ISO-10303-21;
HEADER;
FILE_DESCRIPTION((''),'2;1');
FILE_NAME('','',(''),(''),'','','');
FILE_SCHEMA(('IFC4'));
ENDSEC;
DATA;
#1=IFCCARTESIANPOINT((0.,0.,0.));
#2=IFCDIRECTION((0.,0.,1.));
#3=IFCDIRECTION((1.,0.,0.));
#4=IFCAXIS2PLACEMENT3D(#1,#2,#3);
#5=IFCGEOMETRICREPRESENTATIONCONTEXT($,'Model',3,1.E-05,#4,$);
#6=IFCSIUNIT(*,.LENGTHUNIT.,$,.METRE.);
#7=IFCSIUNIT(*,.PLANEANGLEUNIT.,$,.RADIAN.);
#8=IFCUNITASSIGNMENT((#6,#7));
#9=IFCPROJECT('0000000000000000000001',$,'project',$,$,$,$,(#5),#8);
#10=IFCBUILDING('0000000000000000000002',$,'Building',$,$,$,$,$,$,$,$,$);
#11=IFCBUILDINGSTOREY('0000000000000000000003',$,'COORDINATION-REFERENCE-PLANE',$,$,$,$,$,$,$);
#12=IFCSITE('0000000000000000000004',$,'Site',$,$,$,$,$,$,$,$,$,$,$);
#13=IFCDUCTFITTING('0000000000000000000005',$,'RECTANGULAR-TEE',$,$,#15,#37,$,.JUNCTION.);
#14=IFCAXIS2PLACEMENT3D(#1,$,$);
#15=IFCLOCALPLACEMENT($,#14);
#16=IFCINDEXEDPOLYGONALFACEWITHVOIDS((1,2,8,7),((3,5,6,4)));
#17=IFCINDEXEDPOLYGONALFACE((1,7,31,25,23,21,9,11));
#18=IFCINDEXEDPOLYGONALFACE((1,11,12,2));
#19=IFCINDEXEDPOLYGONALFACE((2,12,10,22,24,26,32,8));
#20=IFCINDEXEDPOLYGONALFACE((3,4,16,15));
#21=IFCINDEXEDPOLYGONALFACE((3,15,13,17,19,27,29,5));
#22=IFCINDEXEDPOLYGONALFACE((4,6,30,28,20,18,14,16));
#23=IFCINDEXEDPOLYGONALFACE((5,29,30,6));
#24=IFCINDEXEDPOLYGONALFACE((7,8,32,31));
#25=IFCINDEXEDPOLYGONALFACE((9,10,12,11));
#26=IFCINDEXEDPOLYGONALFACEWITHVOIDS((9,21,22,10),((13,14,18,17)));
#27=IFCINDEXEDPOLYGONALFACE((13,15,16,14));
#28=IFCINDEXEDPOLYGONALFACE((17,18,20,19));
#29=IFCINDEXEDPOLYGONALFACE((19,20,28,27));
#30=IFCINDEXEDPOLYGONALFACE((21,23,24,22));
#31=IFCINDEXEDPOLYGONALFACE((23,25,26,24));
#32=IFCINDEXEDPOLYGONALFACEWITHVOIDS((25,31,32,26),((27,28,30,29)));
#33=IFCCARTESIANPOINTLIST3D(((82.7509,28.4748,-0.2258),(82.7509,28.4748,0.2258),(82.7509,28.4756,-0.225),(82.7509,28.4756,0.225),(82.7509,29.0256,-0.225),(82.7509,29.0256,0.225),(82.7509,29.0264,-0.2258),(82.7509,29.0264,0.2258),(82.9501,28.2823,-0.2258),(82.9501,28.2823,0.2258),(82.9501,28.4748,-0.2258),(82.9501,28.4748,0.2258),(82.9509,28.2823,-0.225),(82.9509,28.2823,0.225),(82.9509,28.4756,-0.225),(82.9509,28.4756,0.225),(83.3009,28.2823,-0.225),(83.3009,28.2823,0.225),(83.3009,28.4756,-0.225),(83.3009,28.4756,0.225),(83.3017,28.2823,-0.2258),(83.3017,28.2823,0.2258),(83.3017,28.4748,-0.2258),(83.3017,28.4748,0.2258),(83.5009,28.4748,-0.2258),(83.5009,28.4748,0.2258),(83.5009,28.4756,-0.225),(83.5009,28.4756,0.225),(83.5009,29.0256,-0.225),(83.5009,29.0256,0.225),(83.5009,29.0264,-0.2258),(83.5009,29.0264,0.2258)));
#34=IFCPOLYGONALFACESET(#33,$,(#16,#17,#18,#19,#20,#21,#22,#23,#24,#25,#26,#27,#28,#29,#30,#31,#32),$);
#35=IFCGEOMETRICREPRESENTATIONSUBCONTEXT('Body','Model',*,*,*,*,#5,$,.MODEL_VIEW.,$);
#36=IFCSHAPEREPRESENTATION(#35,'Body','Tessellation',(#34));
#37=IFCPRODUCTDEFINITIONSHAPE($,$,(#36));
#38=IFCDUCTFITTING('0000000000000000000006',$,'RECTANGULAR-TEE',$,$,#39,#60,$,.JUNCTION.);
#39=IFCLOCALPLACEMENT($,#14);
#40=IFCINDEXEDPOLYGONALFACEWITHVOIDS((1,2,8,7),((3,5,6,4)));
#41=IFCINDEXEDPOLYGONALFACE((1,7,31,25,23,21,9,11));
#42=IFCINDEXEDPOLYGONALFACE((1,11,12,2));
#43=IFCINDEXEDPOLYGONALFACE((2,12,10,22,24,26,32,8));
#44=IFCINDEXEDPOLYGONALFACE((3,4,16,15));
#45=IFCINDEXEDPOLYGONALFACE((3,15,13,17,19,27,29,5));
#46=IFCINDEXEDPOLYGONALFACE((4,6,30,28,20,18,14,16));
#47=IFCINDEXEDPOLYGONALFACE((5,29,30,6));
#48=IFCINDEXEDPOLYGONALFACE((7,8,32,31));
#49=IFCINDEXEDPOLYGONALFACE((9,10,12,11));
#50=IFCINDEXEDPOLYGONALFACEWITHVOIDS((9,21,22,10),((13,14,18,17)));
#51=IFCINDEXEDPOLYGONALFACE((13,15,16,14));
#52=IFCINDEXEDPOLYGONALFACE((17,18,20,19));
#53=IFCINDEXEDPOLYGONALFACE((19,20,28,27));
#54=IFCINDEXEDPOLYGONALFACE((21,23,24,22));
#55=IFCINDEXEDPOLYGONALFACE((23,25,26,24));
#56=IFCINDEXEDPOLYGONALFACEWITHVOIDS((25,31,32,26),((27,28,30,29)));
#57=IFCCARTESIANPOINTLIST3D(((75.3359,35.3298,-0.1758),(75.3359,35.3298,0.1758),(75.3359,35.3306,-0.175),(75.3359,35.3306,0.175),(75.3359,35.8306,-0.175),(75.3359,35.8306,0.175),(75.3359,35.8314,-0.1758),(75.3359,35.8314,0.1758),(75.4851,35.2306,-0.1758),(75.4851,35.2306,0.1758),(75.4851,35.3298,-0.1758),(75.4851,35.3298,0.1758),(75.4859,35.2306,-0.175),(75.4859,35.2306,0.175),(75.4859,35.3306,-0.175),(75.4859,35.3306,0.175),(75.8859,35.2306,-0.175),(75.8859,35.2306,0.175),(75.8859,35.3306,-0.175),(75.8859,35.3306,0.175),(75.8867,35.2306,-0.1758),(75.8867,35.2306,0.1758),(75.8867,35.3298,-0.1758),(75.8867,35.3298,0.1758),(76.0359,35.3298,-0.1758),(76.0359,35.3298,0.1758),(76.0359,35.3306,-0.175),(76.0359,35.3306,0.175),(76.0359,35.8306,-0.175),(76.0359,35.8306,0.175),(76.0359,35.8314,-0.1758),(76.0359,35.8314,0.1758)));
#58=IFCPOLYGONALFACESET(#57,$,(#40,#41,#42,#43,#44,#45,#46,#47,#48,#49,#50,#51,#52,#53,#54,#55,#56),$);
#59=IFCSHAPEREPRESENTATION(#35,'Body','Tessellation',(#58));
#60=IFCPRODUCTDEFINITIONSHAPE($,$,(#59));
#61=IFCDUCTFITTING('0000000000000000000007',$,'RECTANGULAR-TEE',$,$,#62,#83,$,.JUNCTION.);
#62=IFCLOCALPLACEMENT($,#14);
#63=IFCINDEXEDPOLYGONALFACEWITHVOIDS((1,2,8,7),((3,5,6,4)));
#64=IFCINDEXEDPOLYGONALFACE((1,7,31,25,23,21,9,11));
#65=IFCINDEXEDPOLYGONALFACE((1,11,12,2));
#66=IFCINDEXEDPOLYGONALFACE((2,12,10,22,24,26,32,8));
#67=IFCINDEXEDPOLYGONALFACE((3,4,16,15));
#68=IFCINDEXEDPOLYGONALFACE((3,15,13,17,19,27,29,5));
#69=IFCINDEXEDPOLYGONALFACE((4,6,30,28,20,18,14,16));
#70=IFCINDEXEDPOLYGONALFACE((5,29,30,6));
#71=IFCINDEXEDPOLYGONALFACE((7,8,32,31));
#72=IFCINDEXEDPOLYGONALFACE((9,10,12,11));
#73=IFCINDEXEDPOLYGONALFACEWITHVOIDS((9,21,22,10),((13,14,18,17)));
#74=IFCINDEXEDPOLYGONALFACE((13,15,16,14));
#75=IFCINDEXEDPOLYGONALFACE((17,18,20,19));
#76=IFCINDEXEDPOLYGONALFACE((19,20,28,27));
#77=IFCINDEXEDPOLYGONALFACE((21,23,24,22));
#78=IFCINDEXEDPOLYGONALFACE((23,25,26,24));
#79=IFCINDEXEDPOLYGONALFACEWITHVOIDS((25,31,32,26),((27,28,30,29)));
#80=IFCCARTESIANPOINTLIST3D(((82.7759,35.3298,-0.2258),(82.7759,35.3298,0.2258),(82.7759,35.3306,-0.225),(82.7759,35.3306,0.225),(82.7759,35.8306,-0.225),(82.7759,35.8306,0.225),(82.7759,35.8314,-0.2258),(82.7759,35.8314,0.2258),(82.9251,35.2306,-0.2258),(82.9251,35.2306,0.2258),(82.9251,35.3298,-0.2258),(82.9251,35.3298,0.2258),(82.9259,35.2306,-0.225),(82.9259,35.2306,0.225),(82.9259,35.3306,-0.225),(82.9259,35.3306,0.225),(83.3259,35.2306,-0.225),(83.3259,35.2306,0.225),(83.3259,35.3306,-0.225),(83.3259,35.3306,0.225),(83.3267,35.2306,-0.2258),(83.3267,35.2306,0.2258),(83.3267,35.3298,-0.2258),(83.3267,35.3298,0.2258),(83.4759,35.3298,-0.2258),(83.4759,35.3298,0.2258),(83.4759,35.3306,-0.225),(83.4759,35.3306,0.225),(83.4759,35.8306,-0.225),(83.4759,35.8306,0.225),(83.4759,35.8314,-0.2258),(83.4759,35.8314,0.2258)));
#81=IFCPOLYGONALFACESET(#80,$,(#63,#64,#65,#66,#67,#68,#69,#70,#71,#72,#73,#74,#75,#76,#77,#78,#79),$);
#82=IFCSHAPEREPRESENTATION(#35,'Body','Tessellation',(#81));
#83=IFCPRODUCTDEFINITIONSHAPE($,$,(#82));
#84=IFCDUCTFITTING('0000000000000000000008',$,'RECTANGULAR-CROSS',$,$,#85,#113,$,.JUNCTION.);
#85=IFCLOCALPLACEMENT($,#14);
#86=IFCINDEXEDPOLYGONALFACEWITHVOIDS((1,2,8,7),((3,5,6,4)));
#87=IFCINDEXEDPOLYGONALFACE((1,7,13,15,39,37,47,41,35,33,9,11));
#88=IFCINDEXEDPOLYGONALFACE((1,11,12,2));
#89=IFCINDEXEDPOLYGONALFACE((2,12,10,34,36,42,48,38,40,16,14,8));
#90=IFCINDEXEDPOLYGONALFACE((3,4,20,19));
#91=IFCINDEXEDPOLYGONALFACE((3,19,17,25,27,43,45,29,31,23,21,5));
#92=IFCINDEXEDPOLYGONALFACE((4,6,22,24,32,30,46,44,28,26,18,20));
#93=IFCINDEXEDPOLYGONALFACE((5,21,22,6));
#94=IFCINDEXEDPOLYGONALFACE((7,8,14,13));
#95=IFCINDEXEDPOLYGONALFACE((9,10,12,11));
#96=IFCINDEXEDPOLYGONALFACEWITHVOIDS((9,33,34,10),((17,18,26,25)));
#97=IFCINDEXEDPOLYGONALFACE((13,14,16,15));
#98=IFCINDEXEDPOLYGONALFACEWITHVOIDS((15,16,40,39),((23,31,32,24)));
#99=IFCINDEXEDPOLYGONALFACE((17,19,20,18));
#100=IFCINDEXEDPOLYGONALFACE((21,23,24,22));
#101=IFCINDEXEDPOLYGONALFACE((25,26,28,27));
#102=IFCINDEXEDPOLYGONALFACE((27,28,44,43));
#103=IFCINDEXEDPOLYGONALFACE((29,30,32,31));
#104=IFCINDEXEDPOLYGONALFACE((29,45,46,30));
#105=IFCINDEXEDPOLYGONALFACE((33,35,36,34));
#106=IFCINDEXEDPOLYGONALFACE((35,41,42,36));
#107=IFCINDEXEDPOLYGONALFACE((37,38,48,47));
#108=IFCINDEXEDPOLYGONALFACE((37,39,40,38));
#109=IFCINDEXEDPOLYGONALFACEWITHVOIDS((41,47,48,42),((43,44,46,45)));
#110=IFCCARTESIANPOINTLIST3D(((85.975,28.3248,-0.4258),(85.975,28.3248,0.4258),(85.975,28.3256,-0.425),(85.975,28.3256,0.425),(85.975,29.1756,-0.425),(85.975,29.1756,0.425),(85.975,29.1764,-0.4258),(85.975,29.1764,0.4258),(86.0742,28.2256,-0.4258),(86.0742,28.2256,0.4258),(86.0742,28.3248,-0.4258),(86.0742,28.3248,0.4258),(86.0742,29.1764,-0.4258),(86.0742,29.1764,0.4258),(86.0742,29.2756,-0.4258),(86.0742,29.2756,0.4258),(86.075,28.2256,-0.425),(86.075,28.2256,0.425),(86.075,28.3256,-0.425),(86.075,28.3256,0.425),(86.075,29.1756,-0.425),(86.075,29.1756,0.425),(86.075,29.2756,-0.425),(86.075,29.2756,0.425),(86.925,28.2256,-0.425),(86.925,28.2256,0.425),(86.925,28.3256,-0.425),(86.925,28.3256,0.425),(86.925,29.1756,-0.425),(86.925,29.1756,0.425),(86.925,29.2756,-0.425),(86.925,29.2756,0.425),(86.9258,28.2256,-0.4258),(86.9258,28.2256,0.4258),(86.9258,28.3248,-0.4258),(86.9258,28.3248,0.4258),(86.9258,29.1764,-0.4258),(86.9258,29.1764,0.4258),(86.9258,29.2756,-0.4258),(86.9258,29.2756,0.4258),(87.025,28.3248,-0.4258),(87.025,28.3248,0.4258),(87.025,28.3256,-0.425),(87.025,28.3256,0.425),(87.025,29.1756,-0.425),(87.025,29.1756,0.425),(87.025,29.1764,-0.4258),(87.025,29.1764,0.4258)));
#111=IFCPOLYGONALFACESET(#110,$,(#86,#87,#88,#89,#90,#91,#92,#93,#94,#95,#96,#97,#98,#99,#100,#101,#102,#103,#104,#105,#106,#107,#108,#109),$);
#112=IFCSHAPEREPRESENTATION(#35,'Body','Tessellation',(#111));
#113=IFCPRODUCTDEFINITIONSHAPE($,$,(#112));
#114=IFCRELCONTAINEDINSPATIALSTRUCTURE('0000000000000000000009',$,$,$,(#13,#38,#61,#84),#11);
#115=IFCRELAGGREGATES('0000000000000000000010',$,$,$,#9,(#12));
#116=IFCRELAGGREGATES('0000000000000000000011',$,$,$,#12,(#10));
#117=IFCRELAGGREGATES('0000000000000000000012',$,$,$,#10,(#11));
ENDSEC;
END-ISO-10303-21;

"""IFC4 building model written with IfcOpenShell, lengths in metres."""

from ifc_helpers import new_model, si_unit, frame, origin_with_axes, place, context, subcontext, project, spatial, rectangle, extrude, boolean, element, save


model = new_model("IFC4")

# Units and contexts
model_context = context("Model", 3, precision=1e-05, world=origin_with_axes())
body_context = subcontext(model_context, "Body", "Model", "MODEL_VIEW")
ifc_project = project(units=[si_unit("LENGTHUNIT", "METRE"), si_unit("PLANEANGLEUNIT", "RADIAN")], contexts=[model_context])

# Site, building, storey
site = spatial("IfcSite", under=ifc_project, Name="Site")
building = spatial("IfcBuilding", under=site, Name="Building")
storey = spatial("IfcBuildingStorey", under=building, Name="COORDINATION-REFERENCE-PLANE")

# Duct fittings
duct_fitting_1_placement = place(None, frame((83.1259, 28.7506, 0.0), z_axis=(-1.0, 0.0, 0.0), x_axis=(0.0, -1.0, 0.0)))
solid_1 = boolean("UNION", extrude(rectangle(XDim=0.55, YDim=0.45), frame((0.0, 0.0, -0.375), z_axis=(0.0, 0.0, 1.0), x_axis=(1.0, 0.0, 0.0)), (0.0, 0.0, 1.0), 0.75), extrude(rectangle(XDim=0.35, YDim=0.45), frame((0.0, 0.0, 0.0), z_axis=(1.0, 0.0, 0.0), x_axis=(0.0, 0.0, -1.0)), (0.0, 0.0, 1.0), 0.4683))
element("IfcDuctFitting", 1, at=duct_fitting_1_placement, inside=storey, Name="RECTANGULAR-TEE", PredefinedType="JUNCTION", context=body_context, shape_type="CSG", body=[
    boolean("DIFFERENCE", boolean("UNION", extrude(rectangle(XDim=0.5516, YDim=0.4516), frame((0.0, 0.0, -0.375), z_axis=(0.0, 0.0, 1.0), x_axis=(1.0, 0.0, 0.0)), (0.0, 0.0, 1.0), 0.75), extrude(rectangle(XDim=0.3516, YDim=0.4516), frame((0.0, 0.0, 0.0), z_axis=(1.0, 0.0, 0.0), x_axis=(0.0, 0.0, -1.0)), (0.0, 0.0, 1.0), 0.4683)), solid_1),
])
duct_fitting_2_placement = place(None, frame((75.6859, 35.5806, 0.0), z_axis=(-1.0, 0.0, 0.0), x_axis=(0.0, -1.0, 0.0)))
solid_2 = boolean("UNION", extrude(rectangle(XDim=0.5, YDim=0.35), frame((0.0, 0.0, -0.35), z_axis=(0.0, 0.0, 1.0), x_axis=(1.0, 0.0, 0.0)), (0.0, 0.0, 1.0), 0.7), extrude(rectangle(XDim=0.4, YDim=0.35), frame((0.0, 0.0, 0.0), z_axis=(1.0, 0.0, 0.0), x_axis=(0.0, 0.0, -1.0)), (0.0, 0.0, 1.0), 0.35))
element("IfcDuctFitting", 2, at=duct_fitting_2_placement, inside=storey, Name="RECTANGULAR-TEE", PredefinedType="JUNCTION", context=body_context, shape_type="CSG", body=[
    boolean("DIFFERENCE", boolean("UNION", extrude(rectangle(XDim=0.5016, YDim=0.3516), frame((0.0, 0.0, -0.35), z_axis=(0.0, 0.0, 1.0), x_axis=(1.0, 0.0, 0.0)), (0.0, 0.0, 1.0), 0.7), extrude(rectangle(XDim=0.4016, YDim=0.3516), frame((0.0, 0.0, 0.0), z_axis=(1.0, 0.0, 0.0), x_axis=(0.0, 0.0, -1.0)), (0.0, 0.0, 1.0), 0.35)), solid_2),
])
duct_fitting_3_placement = place(None, frame((83.1259, 35.5806, 0.0), z_axis=(-1.0, 0.0, 0.0), x_axis=(0.0, -1.0, 0.0)))
solid_3 = boolean("UNION", extrude(rectangle(XDim=0.5, YDim=0.45), frame((0.0, 0.0, -0.35), z_axis=(0.0, 0.0, 1.0), x_axis=(1.0, 0.0, 0.0)), (0.0, 0.0, 1.0), 0.7), extrude(rectangle(XDim=0.4, YDim=0.45), frame((0.0, 0.0, 0.0), z_axis=(1.0, 0.0, 0.0), x_axis=(0.0, 0.0, -1.0)), (0.0, 0.0, 1.0), 0.35))
element("IfcDuctFitting", 3, at=duct_fitting_3_placement, inside=storey, Name="RECTANGULAR-TEE", PredefinedType="JUNCTION", context=body_context, shape_type="CSG", body=[
    boolean("DIFFERENCE", boolean("UNION", extrude(rectangle(XDim=0.5016, YDim=0.4516), frame((0.0, 0.0, -0.35), z_axis=(0.0, 0.0, 1.0), x_axis=(1.0, 0.0, 0.0)), (0.0, 0.0, 1.0), 0.7), extrude(rectangle(XDim=0.4016, YDim=0.4516), frame((0.0, 0.0, 0.0), z_axis=(1.0, 0.0, 0.0), x_axis=(0.0, 0.0, -1.0)), (0.0, 0.0, 1.0), 0.35)), solid_3),
])
duct_fitting_4_placement = place(None, frame((86.5, 28.7506, 0.0), z_axis=(0.0, -1.0, 0.0), x_axis=(1.0, 0.0, 0.0)))
solid_4 = boolean("UNION", extrude(rectangle(XDim=0.85, YDim=0.85), frame((0.0, 0.0, -0.525), z_axis=(0.0, 0.0, 1.0), x_axis=(1.0, 0.0, 0.0)), (0.0, 0.0, 1.0), 1.05), extrude(rectangle(XDim=0.85, YDim=0.85), frame((-0.525, 0.0, 0.0), z_axis=(1.0, 0.0, 0.0), x_axis=(0.0, 0.0, -1.0)), (0.0, 0.0, 1.0), 1.05))
element("IfcDuctFitting", 4, at=duct_fitting_4_placement, inside=storey, Name="RECTANGULAR-CROSS", PredefinedType="JUNCTION", context=body_context, shape_type="CSG", body=[
    boolean("DIFFERENCE", boolean("UNION", extrude(rectangle(XDim=0.8516, YDim=0.8516), frame((0.0, 0.0, -0.525), z_axis=(0.0, 0.0, 1.0), x_axis=(1.0, 0.0, 0.0)), (0.0, 0.0, 1.0), 1.05), extrude(rectangle(XDim=0.8516, YDim=0.8516), frame((-0.525, 0.0, 0.0), z_axis=(1.0, 0.0, 0.0), x_axis=(0.0, 0.0, -1.0)), (0.0, 0.0, 1.0), 1.05)), solid_4),
])

save(model, "model.ifc")
